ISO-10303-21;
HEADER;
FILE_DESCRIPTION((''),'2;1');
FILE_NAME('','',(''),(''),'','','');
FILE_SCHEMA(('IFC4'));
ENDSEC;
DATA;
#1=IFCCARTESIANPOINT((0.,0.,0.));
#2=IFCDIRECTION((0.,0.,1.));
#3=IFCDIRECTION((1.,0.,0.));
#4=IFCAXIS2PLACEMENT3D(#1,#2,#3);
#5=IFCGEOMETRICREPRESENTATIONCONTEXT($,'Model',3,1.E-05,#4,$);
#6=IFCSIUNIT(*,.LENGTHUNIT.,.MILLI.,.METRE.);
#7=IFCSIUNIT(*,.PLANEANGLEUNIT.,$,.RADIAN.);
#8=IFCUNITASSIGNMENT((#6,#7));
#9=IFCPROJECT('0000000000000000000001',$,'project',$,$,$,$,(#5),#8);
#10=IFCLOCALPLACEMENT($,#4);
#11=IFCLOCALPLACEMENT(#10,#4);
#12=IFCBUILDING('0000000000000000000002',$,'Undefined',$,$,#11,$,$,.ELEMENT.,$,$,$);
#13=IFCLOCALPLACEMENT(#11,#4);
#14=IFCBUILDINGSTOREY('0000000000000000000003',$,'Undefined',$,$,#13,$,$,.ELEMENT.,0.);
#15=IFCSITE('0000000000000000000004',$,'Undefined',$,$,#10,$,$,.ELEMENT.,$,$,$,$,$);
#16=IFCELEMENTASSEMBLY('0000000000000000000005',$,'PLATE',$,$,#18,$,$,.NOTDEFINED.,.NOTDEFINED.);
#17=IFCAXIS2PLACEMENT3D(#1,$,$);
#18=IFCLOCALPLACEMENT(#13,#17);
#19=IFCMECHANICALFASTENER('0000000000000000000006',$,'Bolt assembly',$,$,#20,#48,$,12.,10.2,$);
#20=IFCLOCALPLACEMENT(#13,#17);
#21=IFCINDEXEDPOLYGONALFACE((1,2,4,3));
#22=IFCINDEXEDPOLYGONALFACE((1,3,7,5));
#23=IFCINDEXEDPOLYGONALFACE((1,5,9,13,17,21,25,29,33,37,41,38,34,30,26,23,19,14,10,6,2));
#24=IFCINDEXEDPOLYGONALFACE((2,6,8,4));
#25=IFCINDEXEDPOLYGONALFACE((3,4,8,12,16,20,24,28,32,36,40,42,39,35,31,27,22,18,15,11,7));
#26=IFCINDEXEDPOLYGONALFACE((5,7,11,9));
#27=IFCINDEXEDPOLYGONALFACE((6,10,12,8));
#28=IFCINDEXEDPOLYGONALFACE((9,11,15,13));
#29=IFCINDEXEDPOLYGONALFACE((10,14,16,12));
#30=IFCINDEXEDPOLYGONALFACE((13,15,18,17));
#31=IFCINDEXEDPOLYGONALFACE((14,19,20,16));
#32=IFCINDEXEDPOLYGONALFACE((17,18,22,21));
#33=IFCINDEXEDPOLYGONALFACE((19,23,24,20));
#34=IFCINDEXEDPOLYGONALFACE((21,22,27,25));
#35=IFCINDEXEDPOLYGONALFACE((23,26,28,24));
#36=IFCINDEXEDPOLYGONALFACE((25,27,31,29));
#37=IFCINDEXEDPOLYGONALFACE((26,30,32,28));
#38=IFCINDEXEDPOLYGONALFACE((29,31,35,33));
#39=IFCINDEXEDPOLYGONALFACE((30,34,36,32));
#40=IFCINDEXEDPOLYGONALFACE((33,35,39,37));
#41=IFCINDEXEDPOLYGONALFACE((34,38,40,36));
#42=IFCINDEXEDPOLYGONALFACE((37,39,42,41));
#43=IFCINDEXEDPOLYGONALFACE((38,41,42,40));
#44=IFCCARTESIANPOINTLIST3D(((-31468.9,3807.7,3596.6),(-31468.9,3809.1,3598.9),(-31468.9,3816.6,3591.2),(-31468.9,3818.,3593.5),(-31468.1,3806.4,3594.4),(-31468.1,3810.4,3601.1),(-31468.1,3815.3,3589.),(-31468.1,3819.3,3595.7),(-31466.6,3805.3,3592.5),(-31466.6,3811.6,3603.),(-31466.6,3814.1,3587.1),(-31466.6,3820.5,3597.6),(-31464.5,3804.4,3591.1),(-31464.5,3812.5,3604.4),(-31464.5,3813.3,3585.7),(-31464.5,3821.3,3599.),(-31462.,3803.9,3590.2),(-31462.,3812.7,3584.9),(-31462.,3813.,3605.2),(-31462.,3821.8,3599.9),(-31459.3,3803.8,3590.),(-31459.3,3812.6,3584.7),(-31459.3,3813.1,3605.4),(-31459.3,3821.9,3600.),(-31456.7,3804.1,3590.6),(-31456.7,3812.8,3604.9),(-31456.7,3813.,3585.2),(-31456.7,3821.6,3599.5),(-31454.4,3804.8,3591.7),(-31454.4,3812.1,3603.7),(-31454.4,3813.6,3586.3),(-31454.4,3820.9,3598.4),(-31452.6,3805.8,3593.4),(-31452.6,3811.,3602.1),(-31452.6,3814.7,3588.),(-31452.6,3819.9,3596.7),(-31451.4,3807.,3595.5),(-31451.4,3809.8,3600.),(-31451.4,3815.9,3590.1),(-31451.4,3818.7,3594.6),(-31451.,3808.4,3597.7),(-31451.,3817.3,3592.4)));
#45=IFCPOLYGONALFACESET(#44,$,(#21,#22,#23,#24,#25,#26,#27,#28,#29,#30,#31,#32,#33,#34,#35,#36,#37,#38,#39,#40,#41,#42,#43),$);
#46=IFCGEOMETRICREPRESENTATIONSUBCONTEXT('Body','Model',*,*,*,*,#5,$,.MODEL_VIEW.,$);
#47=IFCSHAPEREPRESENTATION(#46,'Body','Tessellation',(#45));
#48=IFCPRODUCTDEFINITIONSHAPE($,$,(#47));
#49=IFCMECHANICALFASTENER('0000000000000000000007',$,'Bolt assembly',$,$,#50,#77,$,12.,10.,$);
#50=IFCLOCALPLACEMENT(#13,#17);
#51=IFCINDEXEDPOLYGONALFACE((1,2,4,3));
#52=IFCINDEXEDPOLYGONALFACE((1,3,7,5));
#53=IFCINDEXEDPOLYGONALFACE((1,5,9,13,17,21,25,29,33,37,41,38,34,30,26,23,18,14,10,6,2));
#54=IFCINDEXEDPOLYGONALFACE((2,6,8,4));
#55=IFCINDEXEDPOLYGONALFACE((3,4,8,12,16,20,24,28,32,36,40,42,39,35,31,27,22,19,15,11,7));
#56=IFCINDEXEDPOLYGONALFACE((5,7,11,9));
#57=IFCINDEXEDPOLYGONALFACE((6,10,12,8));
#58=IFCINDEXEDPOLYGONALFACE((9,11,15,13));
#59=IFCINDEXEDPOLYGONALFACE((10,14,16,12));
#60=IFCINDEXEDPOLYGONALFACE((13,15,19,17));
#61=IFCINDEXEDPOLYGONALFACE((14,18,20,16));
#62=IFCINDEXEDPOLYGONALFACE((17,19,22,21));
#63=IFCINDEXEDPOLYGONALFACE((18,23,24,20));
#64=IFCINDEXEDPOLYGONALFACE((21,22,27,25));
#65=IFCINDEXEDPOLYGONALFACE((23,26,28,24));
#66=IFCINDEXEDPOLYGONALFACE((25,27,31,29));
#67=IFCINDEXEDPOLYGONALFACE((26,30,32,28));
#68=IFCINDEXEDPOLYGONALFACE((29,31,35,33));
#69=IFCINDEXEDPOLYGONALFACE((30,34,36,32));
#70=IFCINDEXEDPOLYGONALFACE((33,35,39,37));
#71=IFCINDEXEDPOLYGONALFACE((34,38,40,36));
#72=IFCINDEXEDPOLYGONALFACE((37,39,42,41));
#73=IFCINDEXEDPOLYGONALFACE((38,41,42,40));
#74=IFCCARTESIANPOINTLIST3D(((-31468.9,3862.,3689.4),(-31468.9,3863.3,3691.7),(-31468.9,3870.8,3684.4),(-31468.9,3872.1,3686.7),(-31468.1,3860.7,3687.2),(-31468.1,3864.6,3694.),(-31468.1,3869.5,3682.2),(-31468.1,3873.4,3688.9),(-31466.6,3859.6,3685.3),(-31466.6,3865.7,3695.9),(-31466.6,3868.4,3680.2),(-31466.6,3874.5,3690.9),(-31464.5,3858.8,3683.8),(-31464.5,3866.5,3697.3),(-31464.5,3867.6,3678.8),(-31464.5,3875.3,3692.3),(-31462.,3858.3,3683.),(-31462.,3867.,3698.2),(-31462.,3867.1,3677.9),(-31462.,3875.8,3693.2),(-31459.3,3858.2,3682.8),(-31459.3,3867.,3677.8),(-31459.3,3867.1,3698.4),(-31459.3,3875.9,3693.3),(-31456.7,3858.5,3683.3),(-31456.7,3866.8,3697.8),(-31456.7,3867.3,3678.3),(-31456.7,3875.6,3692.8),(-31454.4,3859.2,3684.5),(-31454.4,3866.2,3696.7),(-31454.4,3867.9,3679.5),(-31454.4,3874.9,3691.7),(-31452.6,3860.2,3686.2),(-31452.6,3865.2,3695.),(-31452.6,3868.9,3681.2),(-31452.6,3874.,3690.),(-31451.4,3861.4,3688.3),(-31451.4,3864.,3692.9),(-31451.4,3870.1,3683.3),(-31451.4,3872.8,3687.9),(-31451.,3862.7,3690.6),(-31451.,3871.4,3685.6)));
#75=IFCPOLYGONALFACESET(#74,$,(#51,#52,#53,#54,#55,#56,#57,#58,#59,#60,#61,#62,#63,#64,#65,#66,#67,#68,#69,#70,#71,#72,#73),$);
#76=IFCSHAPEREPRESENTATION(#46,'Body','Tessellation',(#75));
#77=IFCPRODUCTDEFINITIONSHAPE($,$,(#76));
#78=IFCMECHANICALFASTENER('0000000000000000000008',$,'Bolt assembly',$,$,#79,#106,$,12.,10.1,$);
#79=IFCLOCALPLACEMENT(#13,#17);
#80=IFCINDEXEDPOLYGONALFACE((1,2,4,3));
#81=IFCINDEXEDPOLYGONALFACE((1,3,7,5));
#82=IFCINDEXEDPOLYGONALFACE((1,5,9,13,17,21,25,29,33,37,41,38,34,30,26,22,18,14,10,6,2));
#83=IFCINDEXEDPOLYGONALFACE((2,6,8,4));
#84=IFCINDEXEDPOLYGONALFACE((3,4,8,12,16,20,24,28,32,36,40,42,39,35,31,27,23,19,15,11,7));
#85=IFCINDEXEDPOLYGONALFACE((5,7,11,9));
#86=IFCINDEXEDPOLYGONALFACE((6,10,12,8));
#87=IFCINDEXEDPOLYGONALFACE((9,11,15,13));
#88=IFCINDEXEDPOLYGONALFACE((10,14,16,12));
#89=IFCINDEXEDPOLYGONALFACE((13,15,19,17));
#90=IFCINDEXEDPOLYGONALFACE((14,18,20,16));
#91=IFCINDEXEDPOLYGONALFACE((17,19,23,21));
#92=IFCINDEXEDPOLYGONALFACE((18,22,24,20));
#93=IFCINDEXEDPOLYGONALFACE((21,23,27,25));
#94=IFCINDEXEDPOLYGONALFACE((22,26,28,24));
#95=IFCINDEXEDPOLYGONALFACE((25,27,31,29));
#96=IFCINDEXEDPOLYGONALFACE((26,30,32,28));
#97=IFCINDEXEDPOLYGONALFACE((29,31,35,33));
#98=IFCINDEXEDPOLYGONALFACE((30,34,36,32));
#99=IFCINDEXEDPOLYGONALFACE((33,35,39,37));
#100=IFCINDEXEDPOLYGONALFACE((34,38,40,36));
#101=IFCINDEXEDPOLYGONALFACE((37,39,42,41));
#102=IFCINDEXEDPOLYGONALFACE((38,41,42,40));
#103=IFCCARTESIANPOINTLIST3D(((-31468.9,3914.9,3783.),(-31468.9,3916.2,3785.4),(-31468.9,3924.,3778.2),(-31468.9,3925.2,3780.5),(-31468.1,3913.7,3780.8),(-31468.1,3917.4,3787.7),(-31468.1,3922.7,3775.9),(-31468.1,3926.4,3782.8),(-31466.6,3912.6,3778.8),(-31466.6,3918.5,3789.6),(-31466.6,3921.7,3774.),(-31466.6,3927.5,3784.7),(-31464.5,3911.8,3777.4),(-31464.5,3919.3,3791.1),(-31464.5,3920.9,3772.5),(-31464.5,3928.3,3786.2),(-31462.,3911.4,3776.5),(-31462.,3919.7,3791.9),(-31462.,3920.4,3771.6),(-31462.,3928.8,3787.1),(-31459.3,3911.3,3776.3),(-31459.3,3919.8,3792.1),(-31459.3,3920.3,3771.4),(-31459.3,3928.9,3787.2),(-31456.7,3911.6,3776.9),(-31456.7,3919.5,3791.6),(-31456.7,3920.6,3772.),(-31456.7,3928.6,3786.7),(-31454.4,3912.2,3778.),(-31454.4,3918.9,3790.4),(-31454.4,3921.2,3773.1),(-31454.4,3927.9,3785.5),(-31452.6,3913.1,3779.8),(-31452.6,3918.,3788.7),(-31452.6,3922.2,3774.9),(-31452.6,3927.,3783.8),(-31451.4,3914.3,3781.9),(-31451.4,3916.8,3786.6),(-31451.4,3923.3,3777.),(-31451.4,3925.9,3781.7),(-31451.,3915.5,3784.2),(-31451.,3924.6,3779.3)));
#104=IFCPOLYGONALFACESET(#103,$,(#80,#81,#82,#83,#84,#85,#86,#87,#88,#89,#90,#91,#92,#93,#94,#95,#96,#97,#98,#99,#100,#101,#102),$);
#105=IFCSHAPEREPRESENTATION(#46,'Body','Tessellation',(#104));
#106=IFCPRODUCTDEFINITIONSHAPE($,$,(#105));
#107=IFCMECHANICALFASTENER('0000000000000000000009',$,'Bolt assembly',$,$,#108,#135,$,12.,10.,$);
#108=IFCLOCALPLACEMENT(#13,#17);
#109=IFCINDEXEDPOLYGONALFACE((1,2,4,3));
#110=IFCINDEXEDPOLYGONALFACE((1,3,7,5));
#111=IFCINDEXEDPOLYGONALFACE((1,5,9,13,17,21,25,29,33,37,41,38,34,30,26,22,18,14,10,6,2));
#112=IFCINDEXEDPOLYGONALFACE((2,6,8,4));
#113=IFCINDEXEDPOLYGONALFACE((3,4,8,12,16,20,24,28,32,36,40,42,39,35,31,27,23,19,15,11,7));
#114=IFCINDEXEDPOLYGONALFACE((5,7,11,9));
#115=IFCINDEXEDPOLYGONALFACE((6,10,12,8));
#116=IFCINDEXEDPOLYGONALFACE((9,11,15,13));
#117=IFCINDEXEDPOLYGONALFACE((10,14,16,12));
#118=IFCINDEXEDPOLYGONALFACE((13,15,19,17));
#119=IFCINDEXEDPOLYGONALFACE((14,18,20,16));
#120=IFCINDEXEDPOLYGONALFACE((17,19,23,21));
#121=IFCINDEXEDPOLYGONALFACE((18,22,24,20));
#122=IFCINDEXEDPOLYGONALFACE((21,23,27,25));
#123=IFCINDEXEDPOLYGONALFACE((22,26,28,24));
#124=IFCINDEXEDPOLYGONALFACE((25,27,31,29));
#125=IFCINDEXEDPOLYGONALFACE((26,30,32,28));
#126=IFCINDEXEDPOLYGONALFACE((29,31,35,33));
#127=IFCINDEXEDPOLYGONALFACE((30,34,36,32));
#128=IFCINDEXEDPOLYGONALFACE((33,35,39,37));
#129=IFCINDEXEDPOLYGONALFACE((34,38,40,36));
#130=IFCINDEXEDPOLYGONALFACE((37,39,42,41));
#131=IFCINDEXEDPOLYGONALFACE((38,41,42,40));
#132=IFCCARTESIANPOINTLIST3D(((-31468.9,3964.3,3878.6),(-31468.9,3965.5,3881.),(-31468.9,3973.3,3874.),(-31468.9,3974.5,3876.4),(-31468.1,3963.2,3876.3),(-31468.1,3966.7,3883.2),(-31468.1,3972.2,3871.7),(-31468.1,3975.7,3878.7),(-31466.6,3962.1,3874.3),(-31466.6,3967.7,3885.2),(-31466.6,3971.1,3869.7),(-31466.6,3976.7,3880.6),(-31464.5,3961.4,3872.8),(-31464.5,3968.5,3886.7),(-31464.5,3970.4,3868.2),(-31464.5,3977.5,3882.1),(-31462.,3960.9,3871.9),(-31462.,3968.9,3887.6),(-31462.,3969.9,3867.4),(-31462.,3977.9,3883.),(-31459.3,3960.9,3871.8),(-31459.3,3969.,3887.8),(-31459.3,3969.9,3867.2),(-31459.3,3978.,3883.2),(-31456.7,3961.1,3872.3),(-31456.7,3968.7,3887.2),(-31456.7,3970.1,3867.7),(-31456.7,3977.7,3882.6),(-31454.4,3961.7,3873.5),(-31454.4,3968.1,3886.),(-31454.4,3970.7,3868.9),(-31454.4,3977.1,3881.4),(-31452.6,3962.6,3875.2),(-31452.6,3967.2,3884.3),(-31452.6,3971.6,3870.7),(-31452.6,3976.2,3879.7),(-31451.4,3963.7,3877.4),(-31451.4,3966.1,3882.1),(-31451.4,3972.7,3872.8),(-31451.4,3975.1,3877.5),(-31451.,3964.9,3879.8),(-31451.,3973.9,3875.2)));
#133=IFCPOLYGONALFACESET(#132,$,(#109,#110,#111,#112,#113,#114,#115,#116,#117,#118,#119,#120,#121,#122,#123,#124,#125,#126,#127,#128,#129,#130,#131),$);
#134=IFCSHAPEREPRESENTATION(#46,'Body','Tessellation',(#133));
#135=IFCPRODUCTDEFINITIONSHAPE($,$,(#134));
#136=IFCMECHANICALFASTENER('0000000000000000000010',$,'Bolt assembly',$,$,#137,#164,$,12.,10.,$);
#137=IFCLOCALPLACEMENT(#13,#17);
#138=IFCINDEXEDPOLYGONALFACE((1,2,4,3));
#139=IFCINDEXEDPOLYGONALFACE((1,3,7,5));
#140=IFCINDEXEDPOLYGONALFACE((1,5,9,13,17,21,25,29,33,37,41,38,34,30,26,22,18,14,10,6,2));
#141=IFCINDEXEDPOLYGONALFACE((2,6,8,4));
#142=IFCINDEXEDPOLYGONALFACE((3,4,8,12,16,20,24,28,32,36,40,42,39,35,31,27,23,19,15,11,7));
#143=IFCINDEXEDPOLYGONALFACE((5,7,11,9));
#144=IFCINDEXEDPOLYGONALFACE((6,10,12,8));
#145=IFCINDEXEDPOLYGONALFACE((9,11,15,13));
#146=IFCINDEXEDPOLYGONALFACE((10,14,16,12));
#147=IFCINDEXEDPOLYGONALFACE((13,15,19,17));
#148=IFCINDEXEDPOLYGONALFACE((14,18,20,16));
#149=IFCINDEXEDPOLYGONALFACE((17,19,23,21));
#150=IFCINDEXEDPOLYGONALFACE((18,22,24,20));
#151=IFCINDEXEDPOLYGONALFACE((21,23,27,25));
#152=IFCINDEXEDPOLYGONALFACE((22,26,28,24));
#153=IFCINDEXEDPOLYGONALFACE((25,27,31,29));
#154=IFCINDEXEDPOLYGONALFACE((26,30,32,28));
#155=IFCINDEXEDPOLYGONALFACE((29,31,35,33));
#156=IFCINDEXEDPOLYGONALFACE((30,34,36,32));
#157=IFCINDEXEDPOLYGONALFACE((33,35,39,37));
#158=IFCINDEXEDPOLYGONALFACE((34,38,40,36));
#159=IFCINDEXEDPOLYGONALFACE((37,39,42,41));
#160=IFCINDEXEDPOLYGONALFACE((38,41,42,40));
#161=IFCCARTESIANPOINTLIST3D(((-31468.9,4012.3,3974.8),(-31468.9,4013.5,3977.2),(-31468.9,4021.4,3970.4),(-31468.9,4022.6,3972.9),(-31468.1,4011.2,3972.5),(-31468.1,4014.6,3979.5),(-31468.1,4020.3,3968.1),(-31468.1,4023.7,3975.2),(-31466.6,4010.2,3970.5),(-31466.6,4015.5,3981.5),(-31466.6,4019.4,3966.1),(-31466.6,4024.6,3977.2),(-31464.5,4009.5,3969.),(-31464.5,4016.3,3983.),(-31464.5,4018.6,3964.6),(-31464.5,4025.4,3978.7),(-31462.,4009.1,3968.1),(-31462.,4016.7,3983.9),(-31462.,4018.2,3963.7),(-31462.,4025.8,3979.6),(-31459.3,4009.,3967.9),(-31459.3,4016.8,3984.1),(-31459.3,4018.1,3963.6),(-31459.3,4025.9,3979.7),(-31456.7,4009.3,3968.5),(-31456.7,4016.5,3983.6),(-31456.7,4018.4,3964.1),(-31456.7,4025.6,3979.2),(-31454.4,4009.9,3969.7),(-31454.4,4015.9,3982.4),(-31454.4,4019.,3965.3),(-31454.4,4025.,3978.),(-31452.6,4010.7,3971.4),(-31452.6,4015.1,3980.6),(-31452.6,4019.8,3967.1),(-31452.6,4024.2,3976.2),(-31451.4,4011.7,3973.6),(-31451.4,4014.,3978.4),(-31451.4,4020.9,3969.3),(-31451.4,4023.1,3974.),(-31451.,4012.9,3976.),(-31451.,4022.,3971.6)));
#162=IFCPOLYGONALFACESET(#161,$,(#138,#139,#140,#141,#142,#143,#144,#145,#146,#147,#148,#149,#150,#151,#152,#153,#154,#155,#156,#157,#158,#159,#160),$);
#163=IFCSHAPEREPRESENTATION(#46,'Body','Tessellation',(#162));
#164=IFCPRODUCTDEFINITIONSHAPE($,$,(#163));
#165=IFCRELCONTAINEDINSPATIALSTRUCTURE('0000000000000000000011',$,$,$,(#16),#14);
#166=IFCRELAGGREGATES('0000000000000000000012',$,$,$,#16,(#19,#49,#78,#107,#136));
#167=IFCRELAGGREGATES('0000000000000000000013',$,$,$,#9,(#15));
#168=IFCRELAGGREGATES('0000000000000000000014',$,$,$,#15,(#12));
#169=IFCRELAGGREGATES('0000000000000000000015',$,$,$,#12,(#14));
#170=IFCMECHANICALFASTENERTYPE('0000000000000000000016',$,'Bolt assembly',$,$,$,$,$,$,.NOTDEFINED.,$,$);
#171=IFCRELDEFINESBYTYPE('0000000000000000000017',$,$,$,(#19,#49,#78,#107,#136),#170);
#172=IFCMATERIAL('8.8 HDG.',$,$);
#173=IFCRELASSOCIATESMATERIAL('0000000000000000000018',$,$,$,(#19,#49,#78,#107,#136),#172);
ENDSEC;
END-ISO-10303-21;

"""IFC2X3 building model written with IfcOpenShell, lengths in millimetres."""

from ifc_helpers import new_model, si_unit, frame, origin_with_axes, origin_2d_with_axis, place, context, subcontext, project, spatial, circle, extrude, source, transform, mapped, material, type_object, element, aggregate, save


model = new_model("IFC2X3")

# Units and contexts
model_context = context("Model", 3, precision=1e-05, world=origin_with_axes())
body_context = subcontext(model_context, "Body", "Model", "MODEL_VIEW")
ifc_project = project(units=[si_unit("LENGTHUNIT", "METRE", prefix="MILLI"), si_unit("PLANEANGLEUNIT", "RADIAN")], contexts=[model_context])

# Site, building, storey
site_placement = place(None, origin_with_axes())
site = spatial("IfcSite", under=ifc_project, at=site_placement, Name="Undefined", CompositionType="ELEMENT")
building_placement = place(site_placement, origin_with_axes())
building = spatial("IfcBuilding", under=site, at=building_placement, Name="Undefined", CompositionType="ELEMENT")
storey_placement = place(building_placement, origin_with_axes())
storey = spatial("IfcBuildingStorey", under=building, at=storey_placement, Name="Undefined", CompositionType="ELEMENT", Elevation=0.0)

# Element assembly, mechanical fasteners
assembly_placement = place(storey_placement, origin_with_axes())
assembly = element("IfcElementAssembly", 1, at=assembly_placement, inside=storey, Name="PLATE", AssemblyPlace="NOTDEFINED", PredefinedType="NOTDEFINED")
ifc_material_1 = material(Name="8.8 HDG.")
mechanical_fastener_type = type_object("IfcMechanicalFastenerType", Name="Bolt assembly")
shared_shape_1 = source(origin_with_axes(), body_context, "Body", "SweptSolid", [
    extrude(circle(Radius=9.0, at=origin_2d_with_axis()), frame((0.0, 0.4, 0.0), z_axis=(0.0, 1.0, 0.0), x_axis=(1.0, 0.0, 0.0)), (0.0, 0.0, 1.0), 10.4),
])
mechanical_fastener_1_placement = place(assembly_placement, frame((-31460.0, 3817.6, 3592.2), z_axis=(0.000001, -0.517338, -0.855781), x_axis=(1.0, 0.000001, 0.000001)))
mechanical_fastener_1 = element("IfcMechanicalFastener", 2, at=mechanical_fastener_1_placement, type_object=mechanical_fastener_type, material=ifc_material_1, Name="Bolt assembly", NominalDiameter=12.0, NominalLength=10.2, context=body_context, shape_type="MappedRepresentation", body=[
    mapped(shared_shape_1, transform((0.0, 0.0, 0.0))),
])
shared_shape_2 = source(origin_with_axes(), body_context, "Body", "SweptSolid", [
    extrude(circle(Radius=9.0, at=origin_2d_with_axis()), frame((0.0, 0.9, 0.0), z_axis=(0.0, 1.0, 0.0), x_axis=(1.0, 0.0, 0.0)), (0.0, 0.0, 1.0), 10.1),
])
mechanical_fastener_2_placement = place(assembly_placement, frame((-31460.0, 3872.2, 3685.1), z_axis=(0.000001, -0.496508, -0.868032), x_axis=(1.0, 0.000001, 0.000001)))
mechanical_fastener_2 = element("IfcMechanicalFastener", 3, at=mechanical_fastener_2_placement, type_object=mechanical_fastener_type, material=ifc_material_1, Name="Bolt assembly", NominalDiameter=12.0, NominalLength=10.0, context=body_context, shape_type="MappedRepresentation", body=[
    mapped(shared_shape_2, transform((0.0, 0.0, 0.0))),
])
shared_shape_3 = source(origin_with_axes(), body_context, "Body", "SweptSolid", [
    extrude(circle(Radius=9.0, at=origin_2d_with_axis()), frame((0.0, 0.0, 0.0), z_axis=(0.0, 1.0, 0.0), x_axis=(1.0, 0.0, 0.0)), (0.0, 0.0, 1.0), 10.3),
])
mechanical_fastener_3_placement = place(assembly_placement, frame((-31460.0, 3924.6, 3779.3), z_axis=(0.000001, -0.475388, -0.879776), x_axis=(1.0, 0.000001, 0.000001)))
mechanical_fastener_3 = element("IfcMechanicalFastener", 4, at=mechanical_fastener_3_placement, type_object=mechanical_fastener_type, material=ifc_material_1, Name="Bolt assembly", NominalDiameter=12.0, NominalLength=10.1, context=body_context, shape_type="MappedRepresentation", body=[
    mapped(shared_shape_3, transform((0.0, 0.0, 0.0))),
])
shared_shape_4 = source(origin_with_axes(), body_context, "Body", "SweptSolid", [
    extrude(circle(Radius=9.0, at=origin_2d_with_axis()), frame((0.0, 0.9, 0.0), z_axis=(0.0, 1.0, 0.0), x_axis=(1.0, 0.0, 0.0)), (0.0, 0.0, 1.0), 10.1),
])
mechanical_fastener_4_placement = place(assembly_placement, frame((-31460.0, 3974.7, 3874.8), z_axis=(0.000001, -0.453991, -0.891006), x_axis=(1.0, 0.000001, 0.000001)))
mechanical_fastener_4 = element("IfcMechanicalFastener", 5, at=mechanical_fastener_4_placement, type_object=mechanical_fastener_type, material=ifc_material_1, Name="Bolt assembly", NominalDiameter=12.0, NominalLength=10.0, context=body_context, shape_type="MappedRepresentation", body=[
    mapped(shared_shape_4, transform((0.0, 0.0, 0.0))),
])
shared_shape_5 = source(origin_with_axes(), body_context, "Body", "SweptSolid", [
    extrude(circle(Radius=9.0, at=origin_2d_with_axis()), frame((0.0, 0.6, 0.0), z_axis=(0.0, 1.0, 0.0), x_axis=(1.0, 0.0, 0.0)), (0.0, 0.0, 1.0), 10.1),
])
mechanical_fastener_5_placement = place(assembly_placement, frame((-31460.0, 4022.5, 3971.4), z_axis=(0.000001, -0.432328, -0.901716), x_axis=(1.0, 0.000001, 0.000001)))
mechanical_fastener_5 = element("IfcMechanicalFastener", 6, at=mechanical_fastener_5_placement, type_object=mechanical_fastener_type, material=ifc_material_1, Name="Bolt assembly", NominalDiameter=12.0, NominalLength=10.0, context=body_context, shape_type="MappedRepresentation", body=[
    mapped(shared_shape_5, transform((0.0, 0.0, 0.0))),
])
aggregate(assembly, [mechanical_fastener_1, mechanical_fastener_2, mechanical_fastener_3, mechanical_fastener_4, mechanical_fastener_5])

save(model, "model.ifc")
